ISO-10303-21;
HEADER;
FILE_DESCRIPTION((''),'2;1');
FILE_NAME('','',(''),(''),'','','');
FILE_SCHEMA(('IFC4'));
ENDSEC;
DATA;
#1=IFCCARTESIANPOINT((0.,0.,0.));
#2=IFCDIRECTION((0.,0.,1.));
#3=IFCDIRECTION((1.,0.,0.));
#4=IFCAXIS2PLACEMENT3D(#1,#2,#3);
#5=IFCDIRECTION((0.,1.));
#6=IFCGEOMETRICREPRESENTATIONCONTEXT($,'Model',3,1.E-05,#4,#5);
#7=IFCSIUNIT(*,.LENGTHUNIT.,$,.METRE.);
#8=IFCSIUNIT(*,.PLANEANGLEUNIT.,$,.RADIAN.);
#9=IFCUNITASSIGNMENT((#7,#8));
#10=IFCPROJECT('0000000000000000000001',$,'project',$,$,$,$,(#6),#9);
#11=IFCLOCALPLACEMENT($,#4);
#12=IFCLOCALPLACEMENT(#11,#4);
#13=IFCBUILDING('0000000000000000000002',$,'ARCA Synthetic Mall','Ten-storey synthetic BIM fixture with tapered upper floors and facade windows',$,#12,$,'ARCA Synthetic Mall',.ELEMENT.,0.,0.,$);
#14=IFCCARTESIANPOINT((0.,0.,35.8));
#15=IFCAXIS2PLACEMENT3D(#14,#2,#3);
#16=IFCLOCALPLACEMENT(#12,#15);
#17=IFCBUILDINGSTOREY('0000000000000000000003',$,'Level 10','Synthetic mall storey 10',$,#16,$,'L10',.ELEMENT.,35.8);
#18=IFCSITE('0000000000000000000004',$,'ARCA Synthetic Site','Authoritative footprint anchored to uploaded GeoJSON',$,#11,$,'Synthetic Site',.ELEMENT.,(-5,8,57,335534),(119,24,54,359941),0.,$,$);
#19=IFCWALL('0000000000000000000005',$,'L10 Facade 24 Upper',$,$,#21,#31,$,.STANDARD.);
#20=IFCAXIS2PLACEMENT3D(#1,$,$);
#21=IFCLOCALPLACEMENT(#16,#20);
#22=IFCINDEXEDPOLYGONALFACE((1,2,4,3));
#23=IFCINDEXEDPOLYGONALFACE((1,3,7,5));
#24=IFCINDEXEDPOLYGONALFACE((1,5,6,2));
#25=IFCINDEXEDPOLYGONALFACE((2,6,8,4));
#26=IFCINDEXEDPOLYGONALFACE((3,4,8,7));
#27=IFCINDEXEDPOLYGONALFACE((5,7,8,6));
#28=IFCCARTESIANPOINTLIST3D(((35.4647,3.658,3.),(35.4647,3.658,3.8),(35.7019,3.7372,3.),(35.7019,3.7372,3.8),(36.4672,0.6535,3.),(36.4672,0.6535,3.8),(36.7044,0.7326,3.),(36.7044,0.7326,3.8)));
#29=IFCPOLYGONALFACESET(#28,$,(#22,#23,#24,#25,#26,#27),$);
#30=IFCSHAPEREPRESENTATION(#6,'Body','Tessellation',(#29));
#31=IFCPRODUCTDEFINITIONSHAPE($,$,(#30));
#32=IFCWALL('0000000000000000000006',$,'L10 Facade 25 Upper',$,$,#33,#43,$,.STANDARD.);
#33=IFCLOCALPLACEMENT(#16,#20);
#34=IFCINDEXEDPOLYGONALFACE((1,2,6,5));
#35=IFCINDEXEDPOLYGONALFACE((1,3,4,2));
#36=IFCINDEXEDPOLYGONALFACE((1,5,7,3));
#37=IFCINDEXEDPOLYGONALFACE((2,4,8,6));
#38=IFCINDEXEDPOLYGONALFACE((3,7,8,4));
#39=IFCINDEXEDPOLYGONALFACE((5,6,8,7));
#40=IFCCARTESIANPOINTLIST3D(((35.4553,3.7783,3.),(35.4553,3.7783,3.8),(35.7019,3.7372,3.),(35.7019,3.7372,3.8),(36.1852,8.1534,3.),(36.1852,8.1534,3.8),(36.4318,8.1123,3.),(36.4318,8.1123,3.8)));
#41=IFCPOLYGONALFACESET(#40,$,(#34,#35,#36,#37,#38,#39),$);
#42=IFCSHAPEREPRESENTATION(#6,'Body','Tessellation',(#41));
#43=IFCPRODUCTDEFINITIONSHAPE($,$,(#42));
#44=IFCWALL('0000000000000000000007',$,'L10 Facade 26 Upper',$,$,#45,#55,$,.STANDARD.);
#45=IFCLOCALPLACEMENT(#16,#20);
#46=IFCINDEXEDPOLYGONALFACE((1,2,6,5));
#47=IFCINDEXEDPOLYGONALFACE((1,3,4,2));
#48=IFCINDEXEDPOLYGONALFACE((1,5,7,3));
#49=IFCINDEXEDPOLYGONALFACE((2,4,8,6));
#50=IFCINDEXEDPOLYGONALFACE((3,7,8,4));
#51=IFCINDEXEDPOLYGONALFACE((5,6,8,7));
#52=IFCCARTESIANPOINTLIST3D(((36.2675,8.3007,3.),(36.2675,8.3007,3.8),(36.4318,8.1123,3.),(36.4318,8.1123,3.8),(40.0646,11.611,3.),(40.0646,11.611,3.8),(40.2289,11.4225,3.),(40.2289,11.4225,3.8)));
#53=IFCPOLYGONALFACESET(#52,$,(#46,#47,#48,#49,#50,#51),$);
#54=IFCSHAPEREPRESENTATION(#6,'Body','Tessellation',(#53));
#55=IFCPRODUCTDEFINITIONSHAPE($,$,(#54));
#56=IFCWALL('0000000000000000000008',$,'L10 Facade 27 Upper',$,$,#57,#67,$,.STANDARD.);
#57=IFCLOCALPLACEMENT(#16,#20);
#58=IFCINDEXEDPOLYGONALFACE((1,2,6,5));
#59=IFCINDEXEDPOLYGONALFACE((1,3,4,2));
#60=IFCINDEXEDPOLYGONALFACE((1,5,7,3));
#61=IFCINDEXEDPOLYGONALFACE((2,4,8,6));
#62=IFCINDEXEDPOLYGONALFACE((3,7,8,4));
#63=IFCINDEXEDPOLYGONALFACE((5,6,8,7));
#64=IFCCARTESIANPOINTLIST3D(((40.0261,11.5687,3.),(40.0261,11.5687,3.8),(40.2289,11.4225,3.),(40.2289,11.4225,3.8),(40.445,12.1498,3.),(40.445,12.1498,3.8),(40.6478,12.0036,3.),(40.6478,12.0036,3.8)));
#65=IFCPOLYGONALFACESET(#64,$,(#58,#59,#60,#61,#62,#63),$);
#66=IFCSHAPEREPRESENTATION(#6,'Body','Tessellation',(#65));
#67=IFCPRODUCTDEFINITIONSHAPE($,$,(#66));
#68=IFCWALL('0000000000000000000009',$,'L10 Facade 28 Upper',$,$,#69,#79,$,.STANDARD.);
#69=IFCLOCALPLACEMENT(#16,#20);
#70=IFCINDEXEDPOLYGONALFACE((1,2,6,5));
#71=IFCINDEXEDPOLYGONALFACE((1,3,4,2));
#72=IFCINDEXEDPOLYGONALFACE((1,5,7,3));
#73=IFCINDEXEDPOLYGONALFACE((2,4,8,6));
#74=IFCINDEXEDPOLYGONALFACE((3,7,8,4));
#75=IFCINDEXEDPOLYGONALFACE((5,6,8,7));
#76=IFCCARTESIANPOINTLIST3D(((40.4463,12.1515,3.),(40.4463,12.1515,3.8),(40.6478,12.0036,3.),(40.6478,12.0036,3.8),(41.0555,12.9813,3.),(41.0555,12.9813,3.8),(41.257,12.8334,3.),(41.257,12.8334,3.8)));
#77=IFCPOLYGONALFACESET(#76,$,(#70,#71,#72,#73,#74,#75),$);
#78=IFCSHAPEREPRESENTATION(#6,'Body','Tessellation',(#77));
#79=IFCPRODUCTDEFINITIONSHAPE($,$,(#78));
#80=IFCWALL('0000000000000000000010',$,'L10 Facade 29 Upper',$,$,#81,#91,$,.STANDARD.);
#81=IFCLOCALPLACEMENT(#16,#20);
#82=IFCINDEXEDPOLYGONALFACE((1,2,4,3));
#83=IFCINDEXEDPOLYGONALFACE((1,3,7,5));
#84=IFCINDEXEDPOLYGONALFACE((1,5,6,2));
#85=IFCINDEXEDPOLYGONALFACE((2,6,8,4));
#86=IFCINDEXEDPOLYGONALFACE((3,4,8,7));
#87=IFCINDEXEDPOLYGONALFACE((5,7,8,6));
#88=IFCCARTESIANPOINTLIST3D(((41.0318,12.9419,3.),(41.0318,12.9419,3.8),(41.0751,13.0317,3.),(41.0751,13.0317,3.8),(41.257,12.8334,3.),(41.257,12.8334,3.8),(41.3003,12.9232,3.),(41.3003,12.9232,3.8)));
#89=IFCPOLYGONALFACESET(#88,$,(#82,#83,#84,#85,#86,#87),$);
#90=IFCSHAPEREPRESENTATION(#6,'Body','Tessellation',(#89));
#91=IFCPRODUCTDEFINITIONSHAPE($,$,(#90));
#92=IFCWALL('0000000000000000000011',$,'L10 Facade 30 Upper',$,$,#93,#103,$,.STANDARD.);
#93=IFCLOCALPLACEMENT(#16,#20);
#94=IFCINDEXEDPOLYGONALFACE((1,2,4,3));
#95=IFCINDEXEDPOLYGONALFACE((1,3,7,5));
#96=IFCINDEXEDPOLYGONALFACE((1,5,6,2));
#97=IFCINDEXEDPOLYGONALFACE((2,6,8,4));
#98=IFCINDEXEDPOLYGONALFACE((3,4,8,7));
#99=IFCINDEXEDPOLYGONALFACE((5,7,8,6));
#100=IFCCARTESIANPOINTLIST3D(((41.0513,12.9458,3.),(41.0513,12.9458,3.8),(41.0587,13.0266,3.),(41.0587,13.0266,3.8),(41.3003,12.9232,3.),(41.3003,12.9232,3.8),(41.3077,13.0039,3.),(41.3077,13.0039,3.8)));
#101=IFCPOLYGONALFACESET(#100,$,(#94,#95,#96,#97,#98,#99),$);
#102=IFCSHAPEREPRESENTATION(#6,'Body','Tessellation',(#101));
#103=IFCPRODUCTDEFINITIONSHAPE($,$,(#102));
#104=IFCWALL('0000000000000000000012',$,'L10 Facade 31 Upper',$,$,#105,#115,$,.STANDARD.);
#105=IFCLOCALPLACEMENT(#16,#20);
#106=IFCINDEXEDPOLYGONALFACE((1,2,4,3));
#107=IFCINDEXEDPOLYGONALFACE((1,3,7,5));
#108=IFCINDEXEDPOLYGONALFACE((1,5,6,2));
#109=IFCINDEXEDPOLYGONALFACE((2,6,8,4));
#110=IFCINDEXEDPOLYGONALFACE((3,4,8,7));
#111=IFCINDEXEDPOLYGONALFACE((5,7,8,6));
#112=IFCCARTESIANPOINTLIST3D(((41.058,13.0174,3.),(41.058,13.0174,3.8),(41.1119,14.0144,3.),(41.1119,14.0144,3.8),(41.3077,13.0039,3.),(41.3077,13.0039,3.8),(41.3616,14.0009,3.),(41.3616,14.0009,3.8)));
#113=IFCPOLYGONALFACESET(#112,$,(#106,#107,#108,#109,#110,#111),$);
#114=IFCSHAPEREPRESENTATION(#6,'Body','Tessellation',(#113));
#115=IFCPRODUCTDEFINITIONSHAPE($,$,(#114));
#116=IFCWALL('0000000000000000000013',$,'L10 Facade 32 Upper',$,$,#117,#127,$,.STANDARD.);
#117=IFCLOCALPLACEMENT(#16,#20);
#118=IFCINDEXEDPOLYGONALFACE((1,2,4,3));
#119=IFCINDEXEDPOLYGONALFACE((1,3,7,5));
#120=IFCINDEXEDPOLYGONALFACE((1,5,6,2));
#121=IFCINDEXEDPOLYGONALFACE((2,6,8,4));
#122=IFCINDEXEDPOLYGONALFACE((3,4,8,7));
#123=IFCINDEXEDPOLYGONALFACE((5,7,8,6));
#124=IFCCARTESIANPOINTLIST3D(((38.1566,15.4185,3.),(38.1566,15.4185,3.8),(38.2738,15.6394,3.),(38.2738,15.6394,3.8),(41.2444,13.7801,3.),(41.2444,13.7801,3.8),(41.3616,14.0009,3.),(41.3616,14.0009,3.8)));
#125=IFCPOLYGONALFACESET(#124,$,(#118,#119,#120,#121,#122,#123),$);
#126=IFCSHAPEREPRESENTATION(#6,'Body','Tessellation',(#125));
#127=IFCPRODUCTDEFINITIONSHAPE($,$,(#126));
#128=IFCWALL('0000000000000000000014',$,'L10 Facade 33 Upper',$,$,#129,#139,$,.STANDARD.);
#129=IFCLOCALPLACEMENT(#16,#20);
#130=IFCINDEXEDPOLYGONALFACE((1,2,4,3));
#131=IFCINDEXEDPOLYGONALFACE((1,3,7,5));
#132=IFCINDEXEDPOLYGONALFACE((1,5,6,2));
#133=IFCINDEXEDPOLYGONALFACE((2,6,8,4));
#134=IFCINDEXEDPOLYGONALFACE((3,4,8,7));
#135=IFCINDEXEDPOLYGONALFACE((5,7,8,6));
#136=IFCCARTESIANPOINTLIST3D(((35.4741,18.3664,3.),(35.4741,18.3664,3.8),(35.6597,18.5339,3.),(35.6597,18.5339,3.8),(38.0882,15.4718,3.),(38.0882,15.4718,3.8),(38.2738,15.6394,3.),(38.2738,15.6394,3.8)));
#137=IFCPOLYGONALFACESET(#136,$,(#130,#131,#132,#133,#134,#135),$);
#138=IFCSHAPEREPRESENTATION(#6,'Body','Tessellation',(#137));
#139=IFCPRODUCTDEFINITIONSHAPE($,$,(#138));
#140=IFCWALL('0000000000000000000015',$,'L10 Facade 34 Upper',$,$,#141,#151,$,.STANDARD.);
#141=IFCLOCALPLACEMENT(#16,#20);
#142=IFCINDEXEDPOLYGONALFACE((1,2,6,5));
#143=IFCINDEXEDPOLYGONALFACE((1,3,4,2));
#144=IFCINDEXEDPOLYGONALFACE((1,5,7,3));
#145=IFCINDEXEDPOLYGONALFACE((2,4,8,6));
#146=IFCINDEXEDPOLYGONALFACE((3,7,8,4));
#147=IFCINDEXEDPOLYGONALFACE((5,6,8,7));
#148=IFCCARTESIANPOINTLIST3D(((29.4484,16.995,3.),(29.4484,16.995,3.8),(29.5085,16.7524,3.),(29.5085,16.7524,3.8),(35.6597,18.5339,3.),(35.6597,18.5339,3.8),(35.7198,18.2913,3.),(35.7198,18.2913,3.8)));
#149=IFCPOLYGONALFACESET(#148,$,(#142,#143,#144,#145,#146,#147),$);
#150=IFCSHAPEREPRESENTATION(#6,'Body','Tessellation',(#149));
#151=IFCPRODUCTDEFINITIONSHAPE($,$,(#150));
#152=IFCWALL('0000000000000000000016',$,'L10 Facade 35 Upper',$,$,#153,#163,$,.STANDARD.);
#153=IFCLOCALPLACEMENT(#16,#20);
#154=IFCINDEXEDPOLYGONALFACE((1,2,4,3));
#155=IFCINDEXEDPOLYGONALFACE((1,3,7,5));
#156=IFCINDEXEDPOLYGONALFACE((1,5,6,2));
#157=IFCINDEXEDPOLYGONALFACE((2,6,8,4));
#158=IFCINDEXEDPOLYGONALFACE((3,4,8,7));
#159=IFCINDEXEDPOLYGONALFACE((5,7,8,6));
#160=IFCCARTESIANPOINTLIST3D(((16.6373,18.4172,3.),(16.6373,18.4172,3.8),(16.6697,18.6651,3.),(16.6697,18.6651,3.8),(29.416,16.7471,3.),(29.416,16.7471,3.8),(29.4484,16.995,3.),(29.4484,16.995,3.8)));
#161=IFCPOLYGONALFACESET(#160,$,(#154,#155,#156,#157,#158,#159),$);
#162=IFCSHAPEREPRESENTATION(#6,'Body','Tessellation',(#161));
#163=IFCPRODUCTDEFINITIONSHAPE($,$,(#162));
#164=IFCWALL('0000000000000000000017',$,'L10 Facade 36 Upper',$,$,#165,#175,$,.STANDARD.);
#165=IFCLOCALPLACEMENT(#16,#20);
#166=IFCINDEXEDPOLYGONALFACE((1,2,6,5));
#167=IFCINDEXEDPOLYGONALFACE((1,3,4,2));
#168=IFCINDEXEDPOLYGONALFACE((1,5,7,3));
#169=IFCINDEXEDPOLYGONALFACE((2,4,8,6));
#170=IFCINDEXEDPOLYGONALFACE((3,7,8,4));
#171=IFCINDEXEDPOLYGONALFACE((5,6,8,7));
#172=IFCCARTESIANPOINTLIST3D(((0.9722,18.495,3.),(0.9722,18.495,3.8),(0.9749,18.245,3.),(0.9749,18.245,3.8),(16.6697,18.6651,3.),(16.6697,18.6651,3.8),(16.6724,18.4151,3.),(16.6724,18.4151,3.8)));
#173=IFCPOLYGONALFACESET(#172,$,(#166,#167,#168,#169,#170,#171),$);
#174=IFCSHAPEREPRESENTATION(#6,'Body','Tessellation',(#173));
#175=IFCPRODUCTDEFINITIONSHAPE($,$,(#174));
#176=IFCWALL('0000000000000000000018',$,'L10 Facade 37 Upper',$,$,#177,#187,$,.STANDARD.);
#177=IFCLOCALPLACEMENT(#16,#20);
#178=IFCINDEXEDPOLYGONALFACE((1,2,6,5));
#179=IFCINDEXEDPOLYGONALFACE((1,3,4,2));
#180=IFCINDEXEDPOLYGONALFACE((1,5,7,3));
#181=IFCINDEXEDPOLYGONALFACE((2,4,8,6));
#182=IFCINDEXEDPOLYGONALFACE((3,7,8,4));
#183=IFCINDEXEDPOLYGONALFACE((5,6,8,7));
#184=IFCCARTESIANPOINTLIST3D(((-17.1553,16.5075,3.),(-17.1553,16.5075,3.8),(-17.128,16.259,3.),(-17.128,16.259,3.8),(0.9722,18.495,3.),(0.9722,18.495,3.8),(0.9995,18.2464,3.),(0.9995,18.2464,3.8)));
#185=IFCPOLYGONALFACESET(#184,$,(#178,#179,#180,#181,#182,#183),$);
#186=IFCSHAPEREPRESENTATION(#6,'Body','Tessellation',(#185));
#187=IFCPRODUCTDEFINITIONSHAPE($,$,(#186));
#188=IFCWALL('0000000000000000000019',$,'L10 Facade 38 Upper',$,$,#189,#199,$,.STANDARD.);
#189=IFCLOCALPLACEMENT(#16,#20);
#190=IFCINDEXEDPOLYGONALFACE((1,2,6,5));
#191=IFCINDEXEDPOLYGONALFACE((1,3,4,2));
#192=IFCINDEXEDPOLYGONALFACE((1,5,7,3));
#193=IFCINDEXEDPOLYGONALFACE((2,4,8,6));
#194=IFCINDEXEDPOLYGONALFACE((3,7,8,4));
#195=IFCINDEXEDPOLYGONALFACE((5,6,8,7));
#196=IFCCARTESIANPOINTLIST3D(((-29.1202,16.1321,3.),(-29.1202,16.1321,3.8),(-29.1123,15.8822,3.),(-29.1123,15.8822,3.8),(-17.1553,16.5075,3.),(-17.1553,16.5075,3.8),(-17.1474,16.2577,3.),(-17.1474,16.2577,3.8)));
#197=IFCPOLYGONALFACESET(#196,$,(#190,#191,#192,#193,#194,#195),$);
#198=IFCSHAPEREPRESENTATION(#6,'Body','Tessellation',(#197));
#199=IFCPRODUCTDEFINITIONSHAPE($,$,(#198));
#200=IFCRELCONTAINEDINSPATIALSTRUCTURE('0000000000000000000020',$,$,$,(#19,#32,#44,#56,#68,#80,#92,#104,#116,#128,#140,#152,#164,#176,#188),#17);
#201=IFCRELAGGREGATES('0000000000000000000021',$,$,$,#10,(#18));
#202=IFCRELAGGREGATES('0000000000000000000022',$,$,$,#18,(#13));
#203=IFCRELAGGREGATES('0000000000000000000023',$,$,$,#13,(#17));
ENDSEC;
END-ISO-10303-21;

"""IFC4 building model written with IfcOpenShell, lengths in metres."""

from ifc_helpers import new_model, si_unit, direction, frame, origin_with_axes, place, context, project, spatial, polyline, outline, extrude, element, save


model = new_model("IFC4")

# Units and contexts
model_context = context("Model", 3, precision=1e-05, world=origin_with_axes(), true_north=direction((0.0, 1.0)))
ifc_project = project(units=[si_unit("LENGTHUNIT", "METRE"), si_unit("PLANEANGLEUNIT", "RADIAN")], contexts=[model_context])

# Site, building, storey
site_placement = place(None, origin_with_axes())
site = spatial("IfcSite", under=ifc_project, at=site_placement, Name="ARCA Synthetic Site", Description="Authoritative footprint anchored to uploaded GeoJSON", LongName="Synthetic Site", CompositionType="ELEMENT", RefLatitude=(-5, 8, 57, 335534), RefLongitude=(119, 24, 54, 359941), RefElevation=0.0)
building_placement = place(site_placement, origin_with_axes())
building = spatial("IfcBuilding", under=site, at=building_placement, Name="ARCA Synthetic Mall", Description="Ten-storey synthetic BIM fixture with tapered upper floors and facade windows", LongName="ARCA Synthetic Mall", CompositionType="ELEMENT", ElevationOfRefHeight=0.0, ElevationOfTerrain=0.0)
storey_placement = place(building_placement, frame((0.0, 0.0, 35.8), z_axis=(0.0, 0.0, 1.0), x_axis=(1.0, 0.0, 0.0)))
storey = spatial("IfcBuildingStorey", under=building, at=storey_placement, Name="Level 10", Description="Synthetic mall storey 10", LongName="L10", CompositionType="ELEMENT", Elevation=35.8)

# Walls
wall_1_placement = place(storey_placement, frame((0.0, 0.0, 3.0), z_axis=(0.0, 0.0, 1.0), x_axis=(1.0, 0.0, 0.0)))
element("IfcWall", 1, at=wall_1_placement, inside=storey, Name="L10 Facade 24 Upper", PredefinedType="STANDARD", context=model_context, shape_type="SweptSolid", body=[
    extrude(outline(polyline([(36.7044, 0.7326), (35.7019, 3.7372), (35.4647, 3.658), (36.4672, 0.6535), (36.7044, 0.7326)])), origin_with_axes(), (0.0, 0.0, 1.0), 0.8),
])
wall_2_placement = place(storey_placement, frame((0.0, 0.0, 3.0), z_axis=(0.0, 0.0, 1.0), x_axis=(1.0, 0.0, 0.0)))
element("IfcWall", 2, at=wall_2_placement, inside=storey, Name="L10 Facade 25 Upper", PredefinedType="STANDARD", context=model_context, shape_type="SweptSolid", body=[
    extrude(outline(polyline([(35.7019, 3.7372), (36.4318, 8.1123), (36.1852, 8.1534), (35.4553, 3.7783), (35.7019, 3.7372)])), origin_with_axes(), (0.0, 0.0, 1.0), 0.8),
])
wall_3_placement = place(storey_placement, frame((0.0, 0.0, 3.0), z_axis=(0.0, 0.0, 1.0), x_axis=(1.0, 0.0, 0.0)))
element("IfcWall", 3, at=wall_3_placement, inside=storey, Name="L10 Facade 26 Upper", PredefinedType="STANDARD", context=model_context, shape_type="SweptSolid", body=[
    extrude(outline(polyline([(36.4318, 8.1123), (40.2289, 11.4225), (40.0646, 11.611), (36.2675, 8.3007), (36.4318, 8.1123)])), origin_with_axes(), (0.0, 0.0, 1.0), 0.8),
])
wall_4_placement = place(storey_placement, frame((0.0, 0.0, 3.0), z_axis=(0.0, 0.0, 1.0), x_axis=(1.0, 0.0, 0.0)))
element("IfcWall", 4, at=wall_4_placement, inside=storey, Name="L10 Facade 27 Upper", PredefinedType="STANDARD", context=model_context, shape_type="SweptSolid", body=[
    extrude(outline(polyline([(40.2289, 11.4225), (40.6478, 12.0036), (40.445, 12.1498), (40.0261, 11.5687), (40.2289, 11.4225)])), origin_with_axes(), (0.0, 0.0, 1.0), 0.8),
])
wall_5_placement = place(storey_placement, frame((0.0, 0.0, 3.0), z_axis=(0.0, 0.0, 1.0), x_axis=(1.0, 0.0, 0.0)))
element("IfcWall", 5, at=wall_5_placement, inside=storey, Name="L10 Facade 28 Upper", PredefinedType="STANDARD", context=model_context, shape_type="SweptSolid", body=[
    extrude(outline(polyline([(40.6478, 12.0036), (41.257, 12.8334), (41.0555, 12.9813), (40.4463, 12.1515), (40.6478, 12.0036)])), origin_with_axes(), (0.0, 0.0, 1.0), 0.8),
])
wall_6_placement = place(storey_placement, frame((0.0, 0.0, 3.0), z_axis=(0.0, 0.0, 1.0), x_axis=(1.0, 0.0, 0.0)))
element("IfcWall", 6, at=wall_6_placement, inside=storey, Name="L10 Facade 29 Upper", PredefinedType="STANDARD", context=model_context, shape_type="SweptSolid", body=[
    extrude(outline(polyline([(41.257, 12.8334), (41.3003, 12.9232), (41.0751, 13.0317), (41.0318, 12.9419), (41.257, 12.8334)])), origin_with_axes(), (0.0, 0.0, 1.0), 0.8),
])
wall_7_placement = place(storey_placement, frame((0.0, 0.0, 3.0), z_axis=(0.0, 0.0, 1.0), x_axis=(1.0, 0.0, 0.0)))
element("IfcWall", 7, at=wall_7_placement, inside=storey, Name="L10 Facade 30 Upper", PredefinedType="STANDARD", context=model_context, shape_type="SweptSolid", body=[
    extrude(outline(polyline([(41.3003, 12.9232), (41.3077, 13.0039), (41.0587, 13.0266), (41.0513, 12.9458), (41.3003, 12.9232)])), origin_with_axes(), (0.0, 0.0, 1.0), 0.8),
])
wall_8_placement = place(storey_placement, frame((0.0, 0.0, 3.0), z_axis=(0.0, 0.0, 1.0), x_axis=(1.0, 0.0, 0.0)))
element("IfcWall", 8, at=wall_8_placement, inside=storey, Name="L10 Facade 31 Upper", PredefinedType="STANDARD", context=model_context, shape_type="SweptSolid", body=[
    extrude(outline(polyline([(41.3077, 13.0039), (41.3616, 14.0009), (41.1119, 14.0144), (41.058, 13.0174), (41.3077, 13.0039)])), origin_with_axes(), (0.0, 0.0, 1.0), 0.8),
])
wall_9_placement = place(storey_placement, frame((0.0, 0.0, 3.0), z_axis=(0.0, 0.0, 1.0), x_axis=(1.0, 0.0, 0.0)))
element("IfcWall", 9, at=wall_9_placement, inside=storey, Name="L10 Facade 32 Upper", PredefinedType="STANDARD", context=model_context, shape_type="SweptSolid", body=[
    extrude(outline(polyline([(41.3616, 14.0009), (38.2738, 15.6394), (38.1566, 15.4185), (41.2444, 13.7801), (41.3616, 14.0009)])), origin_with_axes(), (0.0, 0.0, 1.0), 0.8),
])
wall_10_placement = place(storey_placement, frame((0.0, 0.0, 3.0), z_axis=(0.0, 0.0, 1.0), x_axis=(1.0, 0.0, 0.0)))
element("IfcWall", 10, at=wall_10_placement, inside=storey, Name="L10 Facade 33 Upper", PredefinedType="STANDARD", context=model_context, shape_type="SweptSolid", body=[
    extrude(outline(polyline([(38.2738, 15.6394), (35.6597, 18.5339), (35.4741, 18.3664), (38.0882, 15.4718), (38.2738, 15.6394)])), origin_with_axes(), (0.0, 0.0, 1.0), 0.8),
])
wall_11_placement = place(storey_placement, frame((0.0, 0.0, 3.0), z_axis=(0.0, 0.0, 1.0), x_axis=(1.0, 0.0, 0.0)))
element("IfcWall", 11, at=wall_11_placement, inside=storey, Name="L10 Facade 34 Upper", PredefinedType="STANDARD", context=model_context, shape_type="SweptSolid", body=[
    extrude(outline(polyline([(35.6597, 18.5339), (29.4484, 16.995), (29.5085, 16.7524), (35.7198, 18.2913), (35.6597, 18.5339)])), origin_with_axes(), (0.0, 0.0, 1.0), 0.8),
])
wall_12_placement = place(storey_placement, frame((0.0, 0.0, 3.0), z_axis=(0.0, 0.0, 1.0), x_axis=(1.0, 0.0, 0.0)))
element("IfcWall", 12, at=wall_12_placement, inside=storey, Name="L10 Facade 35 Upper", PredefinedType="STANDARD", context=model_context, shape_type="SweptSolid", body=[
    extrude(outline(polyline([(29.4484, 16.995), (16.6697, 18.6651), (16.6373, 18.4172), (29.416, 16.7471), (29.4484, 16.995)])), origin_with_axes(), (0.0, 0.0, 1.0), 0.8),
])
wall_13_placement = place(storey_placement, frame((0.0, 0.0, 3.0), z_axis=(0.0, 0.0, 1.0), x_axis=(1.0, 0.0, 0.0)))
element("IfcWall", 13, at=wall_13_placement, inside=storey, Name="L10 Facade 36 Upper", PredefinedType="STANDARD", context=model_context, shape_type="SweptSolid", body=[
    extrude(outline(polyline([(16.6697, 18.6651), (0.9722, 18.495), (0.9749, 18.245), (16.6724, 18.4151), (16.6697, 18.6651)])), origin_with_axes(), (0.0, 0.0, 1.0), 0.8),
])
wall_14_placement = place(storey_placement, frame((0.0, 0.0, 3.0), z_axis=(0.0, 0.0, 1.0), x_axis=(1.0, 0.0, 0.0)))
element("IfcWall", 14, at=wall_14_placement, inside=storey, Name="L10 Facade 37 Upper", PredefinedType="STANDARD", context=model_context, shape_type="SweptSolid", body=[
    extrude(outline(polyline([(0.9722, 18.495), (-17.1553, 16.5075), (-17.128, 16.259), (0.9995, 18.2464), (0.9722, 18.495)])), origin_with_axes(), (0.0, 0.0, 1.0), 0.8),
])
wall_15_placement = place(storey_placement, frame((0.0, 0.0, 3.0), z_axis=(0.0, 0.0, 1.0), x_axis=(1.0, 0.0, 0.0)))
element("IfcWall", 15, at=wall_15_placement, inside=storey, Name="L10 Facade 38 Upper", PredefinedType="STANDARD", context=model_context, shape_type="SweptSolid", body=[
    extrude(outline(polyline([(-17.1553, 16.5075), (-29.1202, 16.1321), (-29.1123, 15.8822), (-17.1474, 16.2577), (-17.1553, 16.5075)])), origin_with_axes(), (0.0, 0.0, 1.0), 0.8),
])

save(model, "model.ifc")
